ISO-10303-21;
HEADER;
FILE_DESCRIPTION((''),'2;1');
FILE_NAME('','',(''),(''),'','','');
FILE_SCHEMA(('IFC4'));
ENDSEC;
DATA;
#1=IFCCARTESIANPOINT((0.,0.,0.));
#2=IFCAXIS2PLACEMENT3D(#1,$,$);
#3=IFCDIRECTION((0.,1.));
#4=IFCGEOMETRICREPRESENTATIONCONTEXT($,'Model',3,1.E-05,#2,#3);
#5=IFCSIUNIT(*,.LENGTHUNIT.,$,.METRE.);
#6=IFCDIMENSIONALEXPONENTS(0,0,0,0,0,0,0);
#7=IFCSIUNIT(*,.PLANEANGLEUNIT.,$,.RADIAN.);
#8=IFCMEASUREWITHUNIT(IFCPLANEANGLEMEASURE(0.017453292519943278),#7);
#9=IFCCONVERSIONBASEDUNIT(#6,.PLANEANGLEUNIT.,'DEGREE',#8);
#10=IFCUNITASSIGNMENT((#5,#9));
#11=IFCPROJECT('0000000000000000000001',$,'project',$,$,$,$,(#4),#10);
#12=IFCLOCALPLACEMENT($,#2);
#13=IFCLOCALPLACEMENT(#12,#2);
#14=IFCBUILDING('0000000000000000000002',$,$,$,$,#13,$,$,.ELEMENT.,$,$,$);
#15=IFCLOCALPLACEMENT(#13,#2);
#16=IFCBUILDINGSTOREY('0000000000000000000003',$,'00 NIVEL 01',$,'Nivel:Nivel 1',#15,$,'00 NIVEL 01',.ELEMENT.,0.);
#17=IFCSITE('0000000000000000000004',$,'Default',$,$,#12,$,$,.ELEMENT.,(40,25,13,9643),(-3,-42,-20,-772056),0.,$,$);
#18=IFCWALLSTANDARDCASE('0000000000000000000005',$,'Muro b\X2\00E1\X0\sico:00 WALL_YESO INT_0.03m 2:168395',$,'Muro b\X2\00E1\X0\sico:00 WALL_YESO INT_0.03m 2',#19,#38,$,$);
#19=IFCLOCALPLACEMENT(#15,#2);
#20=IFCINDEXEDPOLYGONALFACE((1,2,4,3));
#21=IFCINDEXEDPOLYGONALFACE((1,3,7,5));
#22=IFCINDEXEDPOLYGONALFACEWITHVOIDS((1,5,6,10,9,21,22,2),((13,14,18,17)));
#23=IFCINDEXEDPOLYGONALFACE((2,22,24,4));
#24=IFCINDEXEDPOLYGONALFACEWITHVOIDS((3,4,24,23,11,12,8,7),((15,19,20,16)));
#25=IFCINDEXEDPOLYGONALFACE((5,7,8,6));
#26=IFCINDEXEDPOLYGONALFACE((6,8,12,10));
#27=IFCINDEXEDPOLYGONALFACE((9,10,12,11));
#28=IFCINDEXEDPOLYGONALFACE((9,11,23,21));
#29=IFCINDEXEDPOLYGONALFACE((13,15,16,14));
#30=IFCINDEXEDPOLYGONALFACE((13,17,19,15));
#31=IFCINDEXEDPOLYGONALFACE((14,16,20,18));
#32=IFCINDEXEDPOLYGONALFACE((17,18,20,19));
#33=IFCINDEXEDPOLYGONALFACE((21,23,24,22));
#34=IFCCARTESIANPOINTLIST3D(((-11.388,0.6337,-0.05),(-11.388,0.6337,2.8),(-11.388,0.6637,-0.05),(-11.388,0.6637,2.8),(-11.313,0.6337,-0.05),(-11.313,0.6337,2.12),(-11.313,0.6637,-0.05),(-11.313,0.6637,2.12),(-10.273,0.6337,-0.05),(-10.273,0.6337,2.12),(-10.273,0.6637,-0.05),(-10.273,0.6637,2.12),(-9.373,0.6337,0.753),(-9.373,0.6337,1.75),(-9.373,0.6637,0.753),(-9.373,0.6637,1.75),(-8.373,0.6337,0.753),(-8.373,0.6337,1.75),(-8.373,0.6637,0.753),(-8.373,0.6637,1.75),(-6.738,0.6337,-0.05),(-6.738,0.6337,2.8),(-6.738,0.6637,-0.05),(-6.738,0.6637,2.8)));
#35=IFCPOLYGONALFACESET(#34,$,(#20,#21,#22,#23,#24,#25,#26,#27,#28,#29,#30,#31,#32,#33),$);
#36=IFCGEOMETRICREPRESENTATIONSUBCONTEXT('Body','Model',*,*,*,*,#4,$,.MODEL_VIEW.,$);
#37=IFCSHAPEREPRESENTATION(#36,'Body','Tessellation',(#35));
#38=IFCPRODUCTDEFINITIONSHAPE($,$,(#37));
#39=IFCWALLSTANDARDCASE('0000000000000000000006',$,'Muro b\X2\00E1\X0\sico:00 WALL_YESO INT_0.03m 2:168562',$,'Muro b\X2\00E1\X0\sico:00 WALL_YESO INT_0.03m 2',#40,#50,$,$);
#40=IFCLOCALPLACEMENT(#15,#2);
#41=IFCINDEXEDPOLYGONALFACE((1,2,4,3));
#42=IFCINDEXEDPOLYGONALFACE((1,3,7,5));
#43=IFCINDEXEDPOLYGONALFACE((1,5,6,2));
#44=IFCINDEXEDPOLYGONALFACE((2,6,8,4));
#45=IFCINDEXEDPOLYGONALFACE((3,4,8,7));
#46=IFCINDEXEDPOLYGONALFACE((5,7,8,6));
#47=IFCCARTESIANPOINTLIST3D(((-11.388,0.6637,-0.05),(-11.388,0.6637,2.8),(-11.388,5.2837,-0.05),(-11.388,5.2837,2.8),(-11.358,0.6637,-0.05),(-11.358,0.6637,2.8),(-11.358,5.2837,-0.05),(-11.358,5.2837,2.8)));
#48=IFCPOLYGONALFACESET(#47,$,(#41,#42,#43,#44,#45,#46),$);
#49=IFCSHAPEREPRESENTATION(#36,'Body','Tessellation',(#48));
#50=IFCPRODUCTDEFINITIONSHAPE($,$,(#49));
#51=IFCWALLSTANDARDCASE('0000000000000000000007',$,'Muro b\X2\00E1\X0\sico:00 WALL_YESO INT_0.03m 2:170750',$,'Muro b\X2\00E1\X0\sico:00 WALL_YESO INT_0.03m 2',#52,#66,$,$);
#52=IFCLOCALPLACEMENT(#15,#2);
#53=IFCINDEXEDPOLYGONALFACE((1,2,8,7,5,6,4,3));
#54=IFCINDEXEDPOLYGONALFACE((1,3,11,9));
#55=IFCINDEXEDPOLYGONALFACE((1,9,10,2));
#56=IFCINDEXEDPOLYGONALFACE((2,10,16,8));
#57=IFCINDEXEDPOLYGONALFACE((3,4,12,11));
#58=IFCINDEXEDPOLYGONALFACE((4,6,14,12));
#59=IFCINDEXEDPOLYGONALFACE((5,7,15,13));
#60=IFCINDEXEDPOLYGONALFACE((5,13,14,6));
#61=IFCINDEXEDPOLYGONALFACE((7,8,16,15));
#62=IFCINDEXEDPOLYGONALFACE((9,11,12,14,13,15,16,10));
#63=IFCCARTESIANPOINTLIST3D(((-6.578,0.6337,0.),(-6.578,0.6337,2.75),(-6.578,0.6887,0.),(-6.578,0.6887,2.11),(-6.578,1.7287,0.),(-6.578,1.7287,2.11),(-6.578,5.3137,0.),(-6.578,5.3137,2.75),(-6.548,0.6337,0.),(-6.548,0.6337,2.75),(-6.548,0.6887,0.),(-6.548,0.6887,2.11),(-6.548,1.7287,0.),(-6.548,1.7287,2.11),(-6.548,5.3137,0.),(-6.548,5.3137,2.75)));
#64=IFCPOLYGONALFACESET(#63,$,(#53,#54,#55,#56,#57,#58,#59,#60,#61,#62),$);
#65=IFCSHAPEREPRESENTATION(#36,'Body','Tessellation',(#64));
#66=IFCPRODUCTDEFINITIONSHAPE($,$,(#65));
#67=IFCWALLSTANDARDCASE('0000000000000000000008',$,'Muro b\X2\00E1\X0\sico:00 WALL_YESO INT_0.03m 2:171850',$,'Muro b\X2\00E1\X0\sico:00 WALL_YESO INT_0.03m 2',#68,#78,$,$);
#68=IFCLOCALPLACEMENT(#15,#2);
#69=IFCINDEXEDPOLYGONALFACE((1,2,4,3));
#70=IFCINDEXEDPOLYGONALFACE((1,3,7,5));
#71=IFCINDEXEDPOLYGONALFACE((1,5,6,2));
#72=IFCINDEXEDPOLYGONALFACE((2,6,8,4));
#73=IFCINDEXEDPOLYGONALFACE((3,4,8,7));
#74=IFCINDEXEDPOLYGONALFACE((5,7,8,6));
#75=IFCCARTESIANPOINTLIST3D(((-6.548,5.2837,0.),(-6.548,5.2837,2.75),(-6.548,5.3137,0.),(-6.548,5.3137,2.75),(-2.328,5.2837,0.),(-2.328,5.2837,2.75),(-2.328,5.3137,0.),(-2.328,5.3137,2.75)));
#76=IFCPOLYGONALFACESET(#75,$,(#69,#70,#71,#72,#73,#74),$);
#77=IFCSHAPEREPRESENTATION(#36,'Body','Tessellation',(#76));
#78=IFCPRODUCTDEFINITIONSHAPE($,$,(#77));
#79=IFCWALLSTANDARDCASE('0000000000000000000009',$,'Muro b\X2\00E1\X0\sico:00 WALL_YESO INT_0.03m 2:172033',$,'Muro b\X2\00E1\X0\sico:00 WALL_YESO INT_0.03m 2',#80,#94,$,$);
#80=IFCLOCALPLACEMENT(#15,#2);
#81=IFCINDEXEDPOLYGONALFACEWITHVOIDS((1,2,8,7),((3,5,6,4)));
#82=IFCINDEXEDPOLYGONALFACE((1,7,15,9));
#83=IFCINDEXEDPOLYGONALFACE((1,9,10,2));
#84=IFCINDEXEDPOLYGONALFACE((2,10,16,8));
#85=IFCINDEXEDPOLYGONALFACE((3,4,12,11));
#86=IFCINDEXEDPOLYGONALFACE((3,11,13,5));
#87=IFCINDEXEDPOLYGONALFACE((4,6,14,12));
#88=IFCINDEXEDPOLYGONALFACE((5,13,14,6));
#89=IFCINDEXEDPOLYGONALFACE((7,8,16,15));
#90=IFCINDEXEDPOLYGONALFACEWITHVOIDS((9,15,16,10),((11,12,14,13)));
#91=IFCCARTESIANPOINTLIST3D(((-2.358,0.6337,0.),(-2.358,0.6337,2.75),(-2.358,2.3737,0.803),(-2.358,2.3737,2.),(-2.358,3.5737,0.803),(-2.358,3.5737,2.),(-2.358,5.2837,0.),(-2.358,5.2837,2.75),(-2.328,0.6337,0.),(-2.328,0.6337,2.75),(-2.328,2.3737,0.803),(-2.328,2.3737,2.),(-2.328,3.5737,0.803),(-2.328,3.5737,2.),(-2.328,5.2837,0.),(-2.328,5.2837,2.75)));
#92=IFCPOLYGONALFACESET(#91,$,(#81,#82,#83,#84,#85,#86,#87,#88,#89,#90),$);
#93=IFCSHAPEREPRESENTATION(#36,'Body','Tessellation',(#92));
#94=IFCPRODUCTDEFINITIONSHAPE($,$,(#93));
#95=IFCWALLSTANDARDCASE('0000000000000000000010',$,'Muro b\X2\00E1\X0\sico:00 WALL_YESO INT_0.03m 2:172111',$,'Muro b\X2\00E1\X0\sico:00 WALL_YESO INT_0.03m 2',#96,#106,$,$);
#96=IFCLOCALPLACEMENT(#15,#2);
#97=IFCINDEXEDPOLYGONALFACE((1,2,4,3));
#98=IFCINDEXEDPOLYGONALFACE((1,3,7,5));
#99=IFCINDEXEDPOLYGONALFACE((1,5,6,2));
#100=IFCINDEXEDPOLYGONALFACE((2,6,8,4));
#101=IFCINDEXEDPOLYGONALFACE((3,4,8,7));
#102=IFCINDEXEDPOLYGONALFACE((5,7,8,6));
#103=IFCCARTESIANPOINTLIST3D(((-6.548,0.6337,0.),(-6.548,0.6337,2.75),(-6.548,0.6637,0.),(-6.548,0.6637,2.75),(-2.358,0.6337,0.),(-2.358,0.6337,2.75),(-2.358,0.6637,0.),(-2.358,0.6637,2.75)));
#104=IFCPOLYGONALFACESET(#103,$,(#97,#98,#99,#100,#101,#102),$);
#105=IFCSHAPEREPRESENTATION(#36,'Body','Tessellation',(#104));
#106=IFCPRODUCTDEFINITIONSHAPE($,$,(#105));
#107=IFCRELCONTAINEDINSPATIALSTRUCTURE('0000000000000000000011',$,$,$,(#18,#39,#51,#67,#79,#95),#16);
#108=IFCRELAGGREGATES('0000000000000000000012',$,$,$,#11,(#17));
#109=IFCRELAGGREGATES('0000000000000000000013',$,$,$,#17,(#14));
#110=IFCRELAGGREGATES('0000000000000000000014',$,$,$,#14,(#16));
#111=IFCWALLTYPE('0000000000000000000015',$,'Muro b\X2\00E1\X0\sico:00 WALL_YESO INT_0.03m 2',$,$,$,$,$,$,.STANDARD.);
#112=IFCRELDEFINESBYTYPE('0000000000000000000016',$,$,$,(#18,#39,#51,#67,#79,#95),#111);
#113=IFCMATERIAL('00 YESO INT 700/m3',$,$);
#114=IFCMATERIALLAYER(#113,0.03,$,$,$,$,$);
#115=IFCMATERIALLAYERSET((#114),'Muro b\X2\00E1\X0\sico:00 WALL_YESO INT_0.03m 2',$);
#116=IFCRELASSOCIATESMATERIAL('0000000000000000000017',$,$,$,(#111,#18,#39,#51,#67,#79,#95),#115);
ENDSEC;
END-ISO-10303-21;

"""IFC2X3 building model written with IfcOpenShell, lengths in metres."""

from ifc_helpers import new_model, entity, si_unit, converted_unit, direction, frame, frame_2d, origin, place, context, subcontext, project, spatial, rectangle, extrude, material, layer, layer_set, layer_usage, type_object, element, save


model = new_model("IFC2X3")

# Units and contexts
model_context = context("Model", 3, precision=1e-05, world=origin(), true_north=direction((0.0, 1.0)))
body_context = subcontext(model_context, "Body", "Model", "MODEL_VIEW")
ifc_project = project(units=[si_unit("LENGTHUNIT", "METRE"), converted_unit("PLANEANGLEUNIT", "DEGREE", entity("IfcPlaneAngleMeasure", 0.017453292519943278), si_unit("PLANEANGLEUNIT", "RADIAN"), dimensions=[0, 0, 0, 0, 0, 0, 0])], contexts=[model_context])

# Site, building, storey
site_placement = place(None, origin())
site = spatial("IfcSite", under=ifc_project, at=site_placement, Name="Default", CompositionType="ELEMENT", RefLatitude=(40, 25, 13, 9643), RefLongitude=(-3, -42, -20, -772056), RefElevation=0.0)
building_placement = place(site_placement, origin())
building = spatial("IfcBuilding", under=site, at=building_placement, CompositionType="ELEMENT")
storey_placement = place(building_placement, origin())
storey = spatial("IfcBuildingStorey", under=building, at=storey_placement, Name="00 NIVEL 01", ObjectType="Nivel:Nivel 1", LongName="00 NIVEL 01", CompositionType="ELEMENT", Elevation=0.0)

# Shared definitions
ifc_material_1 = material(Name="00 YESO INT 700/m3")
ifc_layer_1 = layer(ifc_material_1, 0.03)
ifc_layer_set_1 = layer_set([ifc_layer_1], Name="Muro básico:00 WALL_YESO INT_0.03m 2")
wall_type_1 = type_object("IfcWallType", Name="Muro básico:00 WALL_YESO INT_0.03m 2", PredefinedType="STANDARD", material=ifc_layer_set_1)

# Wall, openings
ifc_layer_usage_1 = layer_usage(ifc_layer_set_1, "AXIS2", "NEGATIVE", 0.015)
wall_1_placement = place(storey_placement, frame((-6.738, 0.6487, -0.05), z_axis=(0.0, 0.0, 1.0), x_axis=(-1.0, 0.0, 0.0)))
wall_1 = element("IfcWallStandardCase", 1, at=wall_1_placement, inside=storey, type_object=wall_type_1, material=ifc_layer_usage_1, Name="Muro básico:00 WALL_YESO INT_0.03m 2:168395", ObjectType="Muro básico:00 WALL_YESO INT_0.03m 2", context=body_context, shape_type="SweptSolid", body=[
    extrude(rectangle(XDim=4.65, YDim=0.03, at=frame_2d((2.325, 0.0), x_axis=(-1.0, 0.0))), origin(), (0.0, 0.0, 1.0), 2.85),
])
opening_1_placement = place(wall_1_placement, origin())
element("IfcOpeningElement", 2, at=opening_1_placement, cuts=wall_1, ObjectType="Opening", context=body_context, shape_type="SweptSolid", body=[
    extrude(rectangle(XDim=0.997, YDim=1.0, at=frame_2d((0.0, 0.0), x_axis=(0.0, 1.0))), frame((2.135, 0.015, 1.3015), z_axis=(0.0, -1.0, 0.0), x_axis=(1.0, 0.0, 0.0)), (0.0, 0.0, 1.0), 0.03),
])
opening_2_placement = place(wall_1_placement, origin())
element("IfcOpeningElement", 3, at=opening_2_placement, cuts=wall_1, ObjectType="Opening", context=body_context, shape_type="SweptSolid", body=[
    extrude(rectangle(XDim=2.17, YDim=1.04, at=frame_2d((0.0, 0.0), x_axis=(0.0, 1.0))), frame((4.055, 0.015, 1.085), z_axis=(0.0, -1.0, 0.0), x_axis=(1.0, 0.0, 0.0)), (0.0, 0.0, 1.0), 0.03),
])

# Wall
ifc_layer_usage_2 = layer_usage(ifc_layer_set_1, "AXIS2", "NEGATIVE", 0.015)
wall_2_placement = place(storey_placement, frame((-11.373, 0.6637, -0.05), z_axis=(0.0, 0.0, 1.0), x_axis=(0.0, 1.0, 0.0)))
element("IfcWallStandardCase", 4, at=wall_2_placement, inside=storey, type_object=wall_type_1, material=ifc_layer_usage_2, Name="Muro básico:00 WALL_YESO INT_0.03m 2:168562", ObjectType="Muro básico:00 WALL_YESO INT_0.03m 2", context=body_context, shape_type="SweptSolid", body=[
    extrude(rectangle(XDim=4.62, YDim=0.03, at=frame_2d((2.31, 0.0), x_axis=(-1.0, 0.0))), origin(), (0.0, 0.0, 1.0), 2.85),
])

# Wall, opening
ifc_layer_usage_3 = layer_usage(ifc_layer_set_1, "AXIS2", "POSITIVE", -0.015)
wall_3_placement = place(storey_placement, frame((-6.563, 5.3137, 0.0), z_axis=(0.0, 0.0, 1.0), x_axis=(0.0, -1.0, 0.0)))
wall_3 = element("IfcWallStandardCase", 5, at=wall_3_placement, inside=storey, type_object=wall_type_1, material=ifc_layer_usage_3, Name="Muro básico:00 WALL_YESO INT_0.03m 2:170750", ObjectType="Muro básico:00 WALL_YESO INT_0.03m 2", context=body_context, shape_type="SweptSolid", body=[
    extrude(rectangle(XDim=4.68, YDim=0.03, at=frame_2d((2.34, 0.0), x_axis=(-1.0, 0.0))), origin(), (0.0, 0.0, 1.0), 2.75),
])
opening_3_placement = place(wall_3_placement, origin())
element("IfcOpeningElement", 6, at=opening_3_placement, cuts=wall_3, ObjectType="Opening", context=body_context, shape_type="SweptSolid", body=[
    extrude(rectangle(XDim=2.11, YDim=1.04, at=frame_2d((0.0, 0.0), x_axis=(0.0, 1.0))), frame((4.105, 0.015, 1.055), z_axis=(0.0, -1.0, 0.0), x_axis=(1.0, 0.0, 0.0)), (0.0, 0.0, 1.0), 0.03),
])

# Wall
ifc_layer_usage_4 = layer_usage(ifc_layer_set_1, "AXIS2", "NEGATIVE", 0.015)
wall_4_placement = place(storey_placement, frame((-6.548, 5.2987, 0.0)))
element("IfcWallStandardCase", 7, at=wall_4_placement, inside=storey, type_object=wall_type_1, material=ifc_layer_usage_4, Name="Muro básico:00 WALL_YESO INT_0.03m 2:171850", ObjectType="Muro básico:00 WALL_YESO INT_0.03m 2", context=body_context, shape_type="SweptSolid", body=[
    extrude(rectangle(XDim=4.22, YDim=0.03, at=frame_2d((2.11, 0.0), x_axis=(-1.0, 0.0))), origin(), (0.0, 0.0, 1.0), 2.75),
])

# Wall, opening
ifc_layer_usage_5 = layer_usage(ifc_layer_set_1, "AXIS2", "NEGATIVE", 0.015)
wall_5_placement = place(storey_placement, frame((-2.343, 5.2837, 0.0), z_axis=(0.0, 0.0, 1.0), x_axis=(0.0, -1.0, 0.0)))
wall_5 = element("IfcWallStandardCase", 8, at=wall_5_placement, inside=storey, type_object=wall_type_1, material=ifc_layer_usage_5, Name="Muro básico:00 WALL_YESO INT_0.03m 2:172033", ObjectType="Muro básico:00 WALL_YESO INT_0.03m 2", context=body_context, shape_type="SweptSolid", body=[
    extrude(rectangle(XDim=4.65, YDim=0.03, at=frame_2d((2.325, 0.0), x_axis=(-1.0, 0.0))), origin(), (0.0, 0.0, 1.0), 2.75),
])
opening_4_placement = place(wall_5_placement, origin())
element("IfcOpeningElement", 9, at=opening_4_placement, cuts=wall_5, ObjectType="Opening", context=body_context, shape_type="SweptSolid", body=[
    extrude(rectangle(XDim=1.197, YDim=1.2, at=frame_2d((0.0, 0.0), x_axis=(0.0, -1.0))), frame((2.31, 0.015, 1.4015), z_axis=(0.0, 1.0, 0.0), x_axis=(1.0, 0.0, 0.0)), (0.0, 0.0, -1.0), 0.03),
])

# Wall
ifc_layer_usage_6 = layer_usage(ifc_layer_set_1, "AXIS2", "NEGATIVE", 0.015)
wall_6_placement = place(storey_placement, frame((-2.358, 0.6487, 0.0), z_axis=(0.0, 0.0, 1.0), x_axis=(-1.0, 0.0, 0.0)))
element("IfcWallStandardCase", 10, at=wall_6_placement, inside=storey, type_object=wall_type_1, material=ifc_layer_usage_6, Name="Muro básico:00 WALL_YESO INT_0.03m 2:172111", ObjectType="Muro básico:00 WALL_YESO INT_0.03m 2", context=body_context, shape_type="SweptSolid", body=[
    extrude(rectangle(XDim=4.19, YDim=0.03, at=frame_2d((2.095, 0.0), x_axis=(-1.0, 0.0))), origin(), (0.0, 0.0, 1.0), 2.75),
])

save(model, "model.ifc")
